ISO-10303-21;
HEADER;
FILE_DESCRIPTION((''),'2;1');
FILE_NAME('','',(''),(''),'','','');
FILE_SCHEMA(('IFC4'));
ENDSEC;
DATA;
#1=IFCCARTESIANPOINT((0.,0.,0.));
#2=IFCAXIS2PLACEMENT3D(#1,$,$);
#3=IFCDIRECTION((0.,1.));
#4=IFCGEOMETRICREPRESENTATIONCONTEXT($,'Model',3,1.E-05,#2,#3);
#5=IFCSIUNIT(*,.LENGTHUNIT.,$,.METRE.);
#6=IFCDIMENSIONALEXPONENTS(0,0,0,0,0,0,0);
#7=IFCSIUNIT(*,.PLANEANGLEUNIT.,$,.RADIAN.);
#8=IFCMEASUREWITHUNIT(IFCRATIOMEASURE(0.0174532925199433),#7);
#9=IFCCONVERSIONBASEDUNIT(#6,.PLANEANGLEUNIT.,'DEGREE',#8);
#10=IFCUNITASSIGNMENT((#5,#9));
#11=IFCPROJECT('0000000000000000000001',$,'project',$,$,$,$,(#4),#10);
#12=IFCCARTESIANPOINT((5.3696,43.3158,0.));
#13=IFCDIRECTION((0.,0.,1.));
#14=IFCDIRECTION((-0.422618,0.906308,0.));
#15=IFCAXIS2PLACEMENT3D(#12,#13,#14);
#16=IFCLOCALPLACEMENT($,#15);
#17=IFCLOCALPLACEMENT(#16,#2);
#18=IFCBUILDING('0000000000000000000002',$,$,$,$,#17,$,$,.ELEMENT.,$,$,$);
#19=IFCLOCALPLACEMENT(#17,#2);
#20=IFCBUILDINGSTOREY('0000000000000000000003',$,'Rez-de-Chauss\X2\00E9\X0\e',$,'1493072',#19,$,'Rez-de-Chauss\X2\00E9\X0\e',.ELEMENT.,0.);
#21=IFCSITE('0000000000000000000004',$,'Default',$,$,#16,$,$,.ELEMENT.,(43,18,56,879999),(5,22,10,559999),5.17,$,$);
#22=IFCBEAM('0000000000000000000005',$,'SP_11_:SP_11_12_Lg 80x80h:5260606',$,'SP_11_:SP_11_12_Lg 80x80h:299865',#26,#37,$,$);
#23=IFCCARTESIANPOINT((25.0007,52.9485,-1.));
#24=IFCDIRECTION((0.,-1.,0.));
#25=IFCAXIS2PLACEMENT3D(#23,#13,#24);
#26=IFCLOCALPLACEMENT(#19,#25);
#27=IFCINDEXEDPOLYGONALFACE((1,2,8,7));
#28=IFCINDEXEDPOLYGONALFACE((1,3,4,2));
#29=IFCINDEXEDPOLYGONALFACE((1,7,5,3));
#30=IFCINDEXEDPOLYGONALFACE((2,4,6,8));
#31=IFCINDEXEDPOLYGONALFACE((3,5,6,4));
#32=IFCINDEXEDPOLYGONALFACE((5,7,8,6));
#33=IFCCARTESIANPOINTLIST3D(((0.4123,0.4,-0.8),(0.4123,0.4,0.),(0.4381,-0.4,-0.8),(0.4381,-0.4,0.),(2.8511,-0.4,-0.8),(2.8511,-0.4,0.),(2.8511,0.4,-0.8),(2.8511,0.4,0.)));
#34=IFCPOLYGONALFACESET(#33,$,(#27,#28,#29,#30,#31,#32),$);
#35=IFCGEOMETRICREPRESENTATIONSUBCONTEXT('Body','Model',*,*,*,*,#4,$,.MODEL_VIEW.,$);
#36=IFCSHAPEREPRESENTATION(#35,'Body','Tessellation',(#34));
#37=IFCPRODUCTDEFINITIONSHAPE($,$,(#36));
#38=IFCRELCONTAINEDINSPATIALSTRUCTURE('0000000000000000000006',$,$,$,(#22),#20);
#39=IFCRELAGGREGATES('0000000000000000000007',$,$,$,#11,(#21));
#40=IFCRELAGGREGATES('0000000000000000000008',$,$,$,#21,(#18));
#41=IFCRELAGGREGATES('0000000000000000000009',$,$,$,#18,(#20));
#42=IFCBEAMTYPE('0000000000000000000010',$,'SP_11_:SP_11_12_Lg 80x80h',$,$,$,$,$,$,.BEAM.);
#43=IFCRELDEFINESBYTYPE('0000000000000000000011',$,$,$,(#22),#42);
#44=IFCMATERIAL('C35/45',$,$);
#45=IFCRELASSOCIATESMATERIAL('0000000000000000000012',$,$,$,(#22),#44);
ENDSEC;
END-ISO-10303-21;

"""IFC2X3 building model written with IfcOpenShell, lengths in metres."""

from ifc_helpers import new_model, entity, si_unit, converted_unit, direction, frame, frame_2d, origin, place, context, subcontext, project, spatial, rectangle, extrude, clip, halfspace, material, type_object, element, save


model = new_model("IFC2X3")

# Units and contexts
model_context = context("Model", 3, precision=1e-05, world=origin(), true_north=direction((0.0, 1.0)))
body_context = subcontext(model_context, "Body", "Model", "MODEL_VIEW")
ifc_project = project(units=[si_unit("LENGTHUNIT", "METRE"), converted_unit("PLANEANGLEUNIT", "DEGREE", entity("IfcRatioMeasure", 0.0174532925199433), si_unit("PLANEANGLEUNIT", "RADIAN"), dimensions=[0, 0, 0, 0, 0, 0, 0])], contexts=[model_context])

# Site, building, storey
site_placement = place(None, frame((5.3696, 43.3158, 0.0), z_axis=(0.0, 0.0, 1.0), x_axis=(-0.422618, 0.906308, 0.0)))
site = spatial("IfcSite", under=ifc_project, at=site_placement, Name="Default", CompositionType="ELEMENT", RefLatitude=(43, 18, 56, 879999), RefLongitude=(5, 22, 10, 559999), RefElevation=5.17)
building_placement = place(site_placement, origin())
building = spatial("IfcBuilding", under=site, at=building_placement, CompositionType="ELEMENT")
storey_placement = place(building_placement, origin())
storey = spatial("IfcBuildingStorey", under=building, at=storey_placement, Name="Rez-de-Chaussée", ObjectType="1493072", LongName="Rez-de-Chaussée", CompositionType="ELEMENT", Elevation=0.0)

# Beam
ifc_material_1 = material(Name="C35/45")
beam_type_1 = type_object("IfcBeamType", Name="SP_11_:SP_11_12_Lg 80x80h", PredefinedType="BEAM")
beam_1_placement = place(storey_placement, frame((25.0007, 52.9485, -1.0), z_axis=(0.0, 0.0, 1.0), x_axis=(0.0, -1.0, 0.0)))
element("IfcBeam", 1, at=beam_1_placement, inside=storey, type_object=beam_type_1, material=ifc_material_1, Name="SP_11_:SP_11_12_Lg 80x80h:5260606", ObjectType="SP_11_:SP_11_12_Lg 80x80h:299865", context=body_context, shape_type="Clipping", body=[
    clip(extrude(rectangle(XDim=0.8, YDim=0.8, at=frame_2d((0.0, 0.0), x_axis=(1.0, 0.0))), frame((0.4123, 0.0, -0.4), z_axis=(1.0, 0.0, 0.0), x_axis=(0.0, 0.0, -1.0)), (0.0, 0.0, 1.0), 2.4387), halfspace(frame((-0.4147, 26.0599, 0.0), z_axis=(-0.999481, -0.032213, 0.0), x_axis=(0.032213, -0.999481, 0.0)), False)),
])

save(model, "model.ifc")
